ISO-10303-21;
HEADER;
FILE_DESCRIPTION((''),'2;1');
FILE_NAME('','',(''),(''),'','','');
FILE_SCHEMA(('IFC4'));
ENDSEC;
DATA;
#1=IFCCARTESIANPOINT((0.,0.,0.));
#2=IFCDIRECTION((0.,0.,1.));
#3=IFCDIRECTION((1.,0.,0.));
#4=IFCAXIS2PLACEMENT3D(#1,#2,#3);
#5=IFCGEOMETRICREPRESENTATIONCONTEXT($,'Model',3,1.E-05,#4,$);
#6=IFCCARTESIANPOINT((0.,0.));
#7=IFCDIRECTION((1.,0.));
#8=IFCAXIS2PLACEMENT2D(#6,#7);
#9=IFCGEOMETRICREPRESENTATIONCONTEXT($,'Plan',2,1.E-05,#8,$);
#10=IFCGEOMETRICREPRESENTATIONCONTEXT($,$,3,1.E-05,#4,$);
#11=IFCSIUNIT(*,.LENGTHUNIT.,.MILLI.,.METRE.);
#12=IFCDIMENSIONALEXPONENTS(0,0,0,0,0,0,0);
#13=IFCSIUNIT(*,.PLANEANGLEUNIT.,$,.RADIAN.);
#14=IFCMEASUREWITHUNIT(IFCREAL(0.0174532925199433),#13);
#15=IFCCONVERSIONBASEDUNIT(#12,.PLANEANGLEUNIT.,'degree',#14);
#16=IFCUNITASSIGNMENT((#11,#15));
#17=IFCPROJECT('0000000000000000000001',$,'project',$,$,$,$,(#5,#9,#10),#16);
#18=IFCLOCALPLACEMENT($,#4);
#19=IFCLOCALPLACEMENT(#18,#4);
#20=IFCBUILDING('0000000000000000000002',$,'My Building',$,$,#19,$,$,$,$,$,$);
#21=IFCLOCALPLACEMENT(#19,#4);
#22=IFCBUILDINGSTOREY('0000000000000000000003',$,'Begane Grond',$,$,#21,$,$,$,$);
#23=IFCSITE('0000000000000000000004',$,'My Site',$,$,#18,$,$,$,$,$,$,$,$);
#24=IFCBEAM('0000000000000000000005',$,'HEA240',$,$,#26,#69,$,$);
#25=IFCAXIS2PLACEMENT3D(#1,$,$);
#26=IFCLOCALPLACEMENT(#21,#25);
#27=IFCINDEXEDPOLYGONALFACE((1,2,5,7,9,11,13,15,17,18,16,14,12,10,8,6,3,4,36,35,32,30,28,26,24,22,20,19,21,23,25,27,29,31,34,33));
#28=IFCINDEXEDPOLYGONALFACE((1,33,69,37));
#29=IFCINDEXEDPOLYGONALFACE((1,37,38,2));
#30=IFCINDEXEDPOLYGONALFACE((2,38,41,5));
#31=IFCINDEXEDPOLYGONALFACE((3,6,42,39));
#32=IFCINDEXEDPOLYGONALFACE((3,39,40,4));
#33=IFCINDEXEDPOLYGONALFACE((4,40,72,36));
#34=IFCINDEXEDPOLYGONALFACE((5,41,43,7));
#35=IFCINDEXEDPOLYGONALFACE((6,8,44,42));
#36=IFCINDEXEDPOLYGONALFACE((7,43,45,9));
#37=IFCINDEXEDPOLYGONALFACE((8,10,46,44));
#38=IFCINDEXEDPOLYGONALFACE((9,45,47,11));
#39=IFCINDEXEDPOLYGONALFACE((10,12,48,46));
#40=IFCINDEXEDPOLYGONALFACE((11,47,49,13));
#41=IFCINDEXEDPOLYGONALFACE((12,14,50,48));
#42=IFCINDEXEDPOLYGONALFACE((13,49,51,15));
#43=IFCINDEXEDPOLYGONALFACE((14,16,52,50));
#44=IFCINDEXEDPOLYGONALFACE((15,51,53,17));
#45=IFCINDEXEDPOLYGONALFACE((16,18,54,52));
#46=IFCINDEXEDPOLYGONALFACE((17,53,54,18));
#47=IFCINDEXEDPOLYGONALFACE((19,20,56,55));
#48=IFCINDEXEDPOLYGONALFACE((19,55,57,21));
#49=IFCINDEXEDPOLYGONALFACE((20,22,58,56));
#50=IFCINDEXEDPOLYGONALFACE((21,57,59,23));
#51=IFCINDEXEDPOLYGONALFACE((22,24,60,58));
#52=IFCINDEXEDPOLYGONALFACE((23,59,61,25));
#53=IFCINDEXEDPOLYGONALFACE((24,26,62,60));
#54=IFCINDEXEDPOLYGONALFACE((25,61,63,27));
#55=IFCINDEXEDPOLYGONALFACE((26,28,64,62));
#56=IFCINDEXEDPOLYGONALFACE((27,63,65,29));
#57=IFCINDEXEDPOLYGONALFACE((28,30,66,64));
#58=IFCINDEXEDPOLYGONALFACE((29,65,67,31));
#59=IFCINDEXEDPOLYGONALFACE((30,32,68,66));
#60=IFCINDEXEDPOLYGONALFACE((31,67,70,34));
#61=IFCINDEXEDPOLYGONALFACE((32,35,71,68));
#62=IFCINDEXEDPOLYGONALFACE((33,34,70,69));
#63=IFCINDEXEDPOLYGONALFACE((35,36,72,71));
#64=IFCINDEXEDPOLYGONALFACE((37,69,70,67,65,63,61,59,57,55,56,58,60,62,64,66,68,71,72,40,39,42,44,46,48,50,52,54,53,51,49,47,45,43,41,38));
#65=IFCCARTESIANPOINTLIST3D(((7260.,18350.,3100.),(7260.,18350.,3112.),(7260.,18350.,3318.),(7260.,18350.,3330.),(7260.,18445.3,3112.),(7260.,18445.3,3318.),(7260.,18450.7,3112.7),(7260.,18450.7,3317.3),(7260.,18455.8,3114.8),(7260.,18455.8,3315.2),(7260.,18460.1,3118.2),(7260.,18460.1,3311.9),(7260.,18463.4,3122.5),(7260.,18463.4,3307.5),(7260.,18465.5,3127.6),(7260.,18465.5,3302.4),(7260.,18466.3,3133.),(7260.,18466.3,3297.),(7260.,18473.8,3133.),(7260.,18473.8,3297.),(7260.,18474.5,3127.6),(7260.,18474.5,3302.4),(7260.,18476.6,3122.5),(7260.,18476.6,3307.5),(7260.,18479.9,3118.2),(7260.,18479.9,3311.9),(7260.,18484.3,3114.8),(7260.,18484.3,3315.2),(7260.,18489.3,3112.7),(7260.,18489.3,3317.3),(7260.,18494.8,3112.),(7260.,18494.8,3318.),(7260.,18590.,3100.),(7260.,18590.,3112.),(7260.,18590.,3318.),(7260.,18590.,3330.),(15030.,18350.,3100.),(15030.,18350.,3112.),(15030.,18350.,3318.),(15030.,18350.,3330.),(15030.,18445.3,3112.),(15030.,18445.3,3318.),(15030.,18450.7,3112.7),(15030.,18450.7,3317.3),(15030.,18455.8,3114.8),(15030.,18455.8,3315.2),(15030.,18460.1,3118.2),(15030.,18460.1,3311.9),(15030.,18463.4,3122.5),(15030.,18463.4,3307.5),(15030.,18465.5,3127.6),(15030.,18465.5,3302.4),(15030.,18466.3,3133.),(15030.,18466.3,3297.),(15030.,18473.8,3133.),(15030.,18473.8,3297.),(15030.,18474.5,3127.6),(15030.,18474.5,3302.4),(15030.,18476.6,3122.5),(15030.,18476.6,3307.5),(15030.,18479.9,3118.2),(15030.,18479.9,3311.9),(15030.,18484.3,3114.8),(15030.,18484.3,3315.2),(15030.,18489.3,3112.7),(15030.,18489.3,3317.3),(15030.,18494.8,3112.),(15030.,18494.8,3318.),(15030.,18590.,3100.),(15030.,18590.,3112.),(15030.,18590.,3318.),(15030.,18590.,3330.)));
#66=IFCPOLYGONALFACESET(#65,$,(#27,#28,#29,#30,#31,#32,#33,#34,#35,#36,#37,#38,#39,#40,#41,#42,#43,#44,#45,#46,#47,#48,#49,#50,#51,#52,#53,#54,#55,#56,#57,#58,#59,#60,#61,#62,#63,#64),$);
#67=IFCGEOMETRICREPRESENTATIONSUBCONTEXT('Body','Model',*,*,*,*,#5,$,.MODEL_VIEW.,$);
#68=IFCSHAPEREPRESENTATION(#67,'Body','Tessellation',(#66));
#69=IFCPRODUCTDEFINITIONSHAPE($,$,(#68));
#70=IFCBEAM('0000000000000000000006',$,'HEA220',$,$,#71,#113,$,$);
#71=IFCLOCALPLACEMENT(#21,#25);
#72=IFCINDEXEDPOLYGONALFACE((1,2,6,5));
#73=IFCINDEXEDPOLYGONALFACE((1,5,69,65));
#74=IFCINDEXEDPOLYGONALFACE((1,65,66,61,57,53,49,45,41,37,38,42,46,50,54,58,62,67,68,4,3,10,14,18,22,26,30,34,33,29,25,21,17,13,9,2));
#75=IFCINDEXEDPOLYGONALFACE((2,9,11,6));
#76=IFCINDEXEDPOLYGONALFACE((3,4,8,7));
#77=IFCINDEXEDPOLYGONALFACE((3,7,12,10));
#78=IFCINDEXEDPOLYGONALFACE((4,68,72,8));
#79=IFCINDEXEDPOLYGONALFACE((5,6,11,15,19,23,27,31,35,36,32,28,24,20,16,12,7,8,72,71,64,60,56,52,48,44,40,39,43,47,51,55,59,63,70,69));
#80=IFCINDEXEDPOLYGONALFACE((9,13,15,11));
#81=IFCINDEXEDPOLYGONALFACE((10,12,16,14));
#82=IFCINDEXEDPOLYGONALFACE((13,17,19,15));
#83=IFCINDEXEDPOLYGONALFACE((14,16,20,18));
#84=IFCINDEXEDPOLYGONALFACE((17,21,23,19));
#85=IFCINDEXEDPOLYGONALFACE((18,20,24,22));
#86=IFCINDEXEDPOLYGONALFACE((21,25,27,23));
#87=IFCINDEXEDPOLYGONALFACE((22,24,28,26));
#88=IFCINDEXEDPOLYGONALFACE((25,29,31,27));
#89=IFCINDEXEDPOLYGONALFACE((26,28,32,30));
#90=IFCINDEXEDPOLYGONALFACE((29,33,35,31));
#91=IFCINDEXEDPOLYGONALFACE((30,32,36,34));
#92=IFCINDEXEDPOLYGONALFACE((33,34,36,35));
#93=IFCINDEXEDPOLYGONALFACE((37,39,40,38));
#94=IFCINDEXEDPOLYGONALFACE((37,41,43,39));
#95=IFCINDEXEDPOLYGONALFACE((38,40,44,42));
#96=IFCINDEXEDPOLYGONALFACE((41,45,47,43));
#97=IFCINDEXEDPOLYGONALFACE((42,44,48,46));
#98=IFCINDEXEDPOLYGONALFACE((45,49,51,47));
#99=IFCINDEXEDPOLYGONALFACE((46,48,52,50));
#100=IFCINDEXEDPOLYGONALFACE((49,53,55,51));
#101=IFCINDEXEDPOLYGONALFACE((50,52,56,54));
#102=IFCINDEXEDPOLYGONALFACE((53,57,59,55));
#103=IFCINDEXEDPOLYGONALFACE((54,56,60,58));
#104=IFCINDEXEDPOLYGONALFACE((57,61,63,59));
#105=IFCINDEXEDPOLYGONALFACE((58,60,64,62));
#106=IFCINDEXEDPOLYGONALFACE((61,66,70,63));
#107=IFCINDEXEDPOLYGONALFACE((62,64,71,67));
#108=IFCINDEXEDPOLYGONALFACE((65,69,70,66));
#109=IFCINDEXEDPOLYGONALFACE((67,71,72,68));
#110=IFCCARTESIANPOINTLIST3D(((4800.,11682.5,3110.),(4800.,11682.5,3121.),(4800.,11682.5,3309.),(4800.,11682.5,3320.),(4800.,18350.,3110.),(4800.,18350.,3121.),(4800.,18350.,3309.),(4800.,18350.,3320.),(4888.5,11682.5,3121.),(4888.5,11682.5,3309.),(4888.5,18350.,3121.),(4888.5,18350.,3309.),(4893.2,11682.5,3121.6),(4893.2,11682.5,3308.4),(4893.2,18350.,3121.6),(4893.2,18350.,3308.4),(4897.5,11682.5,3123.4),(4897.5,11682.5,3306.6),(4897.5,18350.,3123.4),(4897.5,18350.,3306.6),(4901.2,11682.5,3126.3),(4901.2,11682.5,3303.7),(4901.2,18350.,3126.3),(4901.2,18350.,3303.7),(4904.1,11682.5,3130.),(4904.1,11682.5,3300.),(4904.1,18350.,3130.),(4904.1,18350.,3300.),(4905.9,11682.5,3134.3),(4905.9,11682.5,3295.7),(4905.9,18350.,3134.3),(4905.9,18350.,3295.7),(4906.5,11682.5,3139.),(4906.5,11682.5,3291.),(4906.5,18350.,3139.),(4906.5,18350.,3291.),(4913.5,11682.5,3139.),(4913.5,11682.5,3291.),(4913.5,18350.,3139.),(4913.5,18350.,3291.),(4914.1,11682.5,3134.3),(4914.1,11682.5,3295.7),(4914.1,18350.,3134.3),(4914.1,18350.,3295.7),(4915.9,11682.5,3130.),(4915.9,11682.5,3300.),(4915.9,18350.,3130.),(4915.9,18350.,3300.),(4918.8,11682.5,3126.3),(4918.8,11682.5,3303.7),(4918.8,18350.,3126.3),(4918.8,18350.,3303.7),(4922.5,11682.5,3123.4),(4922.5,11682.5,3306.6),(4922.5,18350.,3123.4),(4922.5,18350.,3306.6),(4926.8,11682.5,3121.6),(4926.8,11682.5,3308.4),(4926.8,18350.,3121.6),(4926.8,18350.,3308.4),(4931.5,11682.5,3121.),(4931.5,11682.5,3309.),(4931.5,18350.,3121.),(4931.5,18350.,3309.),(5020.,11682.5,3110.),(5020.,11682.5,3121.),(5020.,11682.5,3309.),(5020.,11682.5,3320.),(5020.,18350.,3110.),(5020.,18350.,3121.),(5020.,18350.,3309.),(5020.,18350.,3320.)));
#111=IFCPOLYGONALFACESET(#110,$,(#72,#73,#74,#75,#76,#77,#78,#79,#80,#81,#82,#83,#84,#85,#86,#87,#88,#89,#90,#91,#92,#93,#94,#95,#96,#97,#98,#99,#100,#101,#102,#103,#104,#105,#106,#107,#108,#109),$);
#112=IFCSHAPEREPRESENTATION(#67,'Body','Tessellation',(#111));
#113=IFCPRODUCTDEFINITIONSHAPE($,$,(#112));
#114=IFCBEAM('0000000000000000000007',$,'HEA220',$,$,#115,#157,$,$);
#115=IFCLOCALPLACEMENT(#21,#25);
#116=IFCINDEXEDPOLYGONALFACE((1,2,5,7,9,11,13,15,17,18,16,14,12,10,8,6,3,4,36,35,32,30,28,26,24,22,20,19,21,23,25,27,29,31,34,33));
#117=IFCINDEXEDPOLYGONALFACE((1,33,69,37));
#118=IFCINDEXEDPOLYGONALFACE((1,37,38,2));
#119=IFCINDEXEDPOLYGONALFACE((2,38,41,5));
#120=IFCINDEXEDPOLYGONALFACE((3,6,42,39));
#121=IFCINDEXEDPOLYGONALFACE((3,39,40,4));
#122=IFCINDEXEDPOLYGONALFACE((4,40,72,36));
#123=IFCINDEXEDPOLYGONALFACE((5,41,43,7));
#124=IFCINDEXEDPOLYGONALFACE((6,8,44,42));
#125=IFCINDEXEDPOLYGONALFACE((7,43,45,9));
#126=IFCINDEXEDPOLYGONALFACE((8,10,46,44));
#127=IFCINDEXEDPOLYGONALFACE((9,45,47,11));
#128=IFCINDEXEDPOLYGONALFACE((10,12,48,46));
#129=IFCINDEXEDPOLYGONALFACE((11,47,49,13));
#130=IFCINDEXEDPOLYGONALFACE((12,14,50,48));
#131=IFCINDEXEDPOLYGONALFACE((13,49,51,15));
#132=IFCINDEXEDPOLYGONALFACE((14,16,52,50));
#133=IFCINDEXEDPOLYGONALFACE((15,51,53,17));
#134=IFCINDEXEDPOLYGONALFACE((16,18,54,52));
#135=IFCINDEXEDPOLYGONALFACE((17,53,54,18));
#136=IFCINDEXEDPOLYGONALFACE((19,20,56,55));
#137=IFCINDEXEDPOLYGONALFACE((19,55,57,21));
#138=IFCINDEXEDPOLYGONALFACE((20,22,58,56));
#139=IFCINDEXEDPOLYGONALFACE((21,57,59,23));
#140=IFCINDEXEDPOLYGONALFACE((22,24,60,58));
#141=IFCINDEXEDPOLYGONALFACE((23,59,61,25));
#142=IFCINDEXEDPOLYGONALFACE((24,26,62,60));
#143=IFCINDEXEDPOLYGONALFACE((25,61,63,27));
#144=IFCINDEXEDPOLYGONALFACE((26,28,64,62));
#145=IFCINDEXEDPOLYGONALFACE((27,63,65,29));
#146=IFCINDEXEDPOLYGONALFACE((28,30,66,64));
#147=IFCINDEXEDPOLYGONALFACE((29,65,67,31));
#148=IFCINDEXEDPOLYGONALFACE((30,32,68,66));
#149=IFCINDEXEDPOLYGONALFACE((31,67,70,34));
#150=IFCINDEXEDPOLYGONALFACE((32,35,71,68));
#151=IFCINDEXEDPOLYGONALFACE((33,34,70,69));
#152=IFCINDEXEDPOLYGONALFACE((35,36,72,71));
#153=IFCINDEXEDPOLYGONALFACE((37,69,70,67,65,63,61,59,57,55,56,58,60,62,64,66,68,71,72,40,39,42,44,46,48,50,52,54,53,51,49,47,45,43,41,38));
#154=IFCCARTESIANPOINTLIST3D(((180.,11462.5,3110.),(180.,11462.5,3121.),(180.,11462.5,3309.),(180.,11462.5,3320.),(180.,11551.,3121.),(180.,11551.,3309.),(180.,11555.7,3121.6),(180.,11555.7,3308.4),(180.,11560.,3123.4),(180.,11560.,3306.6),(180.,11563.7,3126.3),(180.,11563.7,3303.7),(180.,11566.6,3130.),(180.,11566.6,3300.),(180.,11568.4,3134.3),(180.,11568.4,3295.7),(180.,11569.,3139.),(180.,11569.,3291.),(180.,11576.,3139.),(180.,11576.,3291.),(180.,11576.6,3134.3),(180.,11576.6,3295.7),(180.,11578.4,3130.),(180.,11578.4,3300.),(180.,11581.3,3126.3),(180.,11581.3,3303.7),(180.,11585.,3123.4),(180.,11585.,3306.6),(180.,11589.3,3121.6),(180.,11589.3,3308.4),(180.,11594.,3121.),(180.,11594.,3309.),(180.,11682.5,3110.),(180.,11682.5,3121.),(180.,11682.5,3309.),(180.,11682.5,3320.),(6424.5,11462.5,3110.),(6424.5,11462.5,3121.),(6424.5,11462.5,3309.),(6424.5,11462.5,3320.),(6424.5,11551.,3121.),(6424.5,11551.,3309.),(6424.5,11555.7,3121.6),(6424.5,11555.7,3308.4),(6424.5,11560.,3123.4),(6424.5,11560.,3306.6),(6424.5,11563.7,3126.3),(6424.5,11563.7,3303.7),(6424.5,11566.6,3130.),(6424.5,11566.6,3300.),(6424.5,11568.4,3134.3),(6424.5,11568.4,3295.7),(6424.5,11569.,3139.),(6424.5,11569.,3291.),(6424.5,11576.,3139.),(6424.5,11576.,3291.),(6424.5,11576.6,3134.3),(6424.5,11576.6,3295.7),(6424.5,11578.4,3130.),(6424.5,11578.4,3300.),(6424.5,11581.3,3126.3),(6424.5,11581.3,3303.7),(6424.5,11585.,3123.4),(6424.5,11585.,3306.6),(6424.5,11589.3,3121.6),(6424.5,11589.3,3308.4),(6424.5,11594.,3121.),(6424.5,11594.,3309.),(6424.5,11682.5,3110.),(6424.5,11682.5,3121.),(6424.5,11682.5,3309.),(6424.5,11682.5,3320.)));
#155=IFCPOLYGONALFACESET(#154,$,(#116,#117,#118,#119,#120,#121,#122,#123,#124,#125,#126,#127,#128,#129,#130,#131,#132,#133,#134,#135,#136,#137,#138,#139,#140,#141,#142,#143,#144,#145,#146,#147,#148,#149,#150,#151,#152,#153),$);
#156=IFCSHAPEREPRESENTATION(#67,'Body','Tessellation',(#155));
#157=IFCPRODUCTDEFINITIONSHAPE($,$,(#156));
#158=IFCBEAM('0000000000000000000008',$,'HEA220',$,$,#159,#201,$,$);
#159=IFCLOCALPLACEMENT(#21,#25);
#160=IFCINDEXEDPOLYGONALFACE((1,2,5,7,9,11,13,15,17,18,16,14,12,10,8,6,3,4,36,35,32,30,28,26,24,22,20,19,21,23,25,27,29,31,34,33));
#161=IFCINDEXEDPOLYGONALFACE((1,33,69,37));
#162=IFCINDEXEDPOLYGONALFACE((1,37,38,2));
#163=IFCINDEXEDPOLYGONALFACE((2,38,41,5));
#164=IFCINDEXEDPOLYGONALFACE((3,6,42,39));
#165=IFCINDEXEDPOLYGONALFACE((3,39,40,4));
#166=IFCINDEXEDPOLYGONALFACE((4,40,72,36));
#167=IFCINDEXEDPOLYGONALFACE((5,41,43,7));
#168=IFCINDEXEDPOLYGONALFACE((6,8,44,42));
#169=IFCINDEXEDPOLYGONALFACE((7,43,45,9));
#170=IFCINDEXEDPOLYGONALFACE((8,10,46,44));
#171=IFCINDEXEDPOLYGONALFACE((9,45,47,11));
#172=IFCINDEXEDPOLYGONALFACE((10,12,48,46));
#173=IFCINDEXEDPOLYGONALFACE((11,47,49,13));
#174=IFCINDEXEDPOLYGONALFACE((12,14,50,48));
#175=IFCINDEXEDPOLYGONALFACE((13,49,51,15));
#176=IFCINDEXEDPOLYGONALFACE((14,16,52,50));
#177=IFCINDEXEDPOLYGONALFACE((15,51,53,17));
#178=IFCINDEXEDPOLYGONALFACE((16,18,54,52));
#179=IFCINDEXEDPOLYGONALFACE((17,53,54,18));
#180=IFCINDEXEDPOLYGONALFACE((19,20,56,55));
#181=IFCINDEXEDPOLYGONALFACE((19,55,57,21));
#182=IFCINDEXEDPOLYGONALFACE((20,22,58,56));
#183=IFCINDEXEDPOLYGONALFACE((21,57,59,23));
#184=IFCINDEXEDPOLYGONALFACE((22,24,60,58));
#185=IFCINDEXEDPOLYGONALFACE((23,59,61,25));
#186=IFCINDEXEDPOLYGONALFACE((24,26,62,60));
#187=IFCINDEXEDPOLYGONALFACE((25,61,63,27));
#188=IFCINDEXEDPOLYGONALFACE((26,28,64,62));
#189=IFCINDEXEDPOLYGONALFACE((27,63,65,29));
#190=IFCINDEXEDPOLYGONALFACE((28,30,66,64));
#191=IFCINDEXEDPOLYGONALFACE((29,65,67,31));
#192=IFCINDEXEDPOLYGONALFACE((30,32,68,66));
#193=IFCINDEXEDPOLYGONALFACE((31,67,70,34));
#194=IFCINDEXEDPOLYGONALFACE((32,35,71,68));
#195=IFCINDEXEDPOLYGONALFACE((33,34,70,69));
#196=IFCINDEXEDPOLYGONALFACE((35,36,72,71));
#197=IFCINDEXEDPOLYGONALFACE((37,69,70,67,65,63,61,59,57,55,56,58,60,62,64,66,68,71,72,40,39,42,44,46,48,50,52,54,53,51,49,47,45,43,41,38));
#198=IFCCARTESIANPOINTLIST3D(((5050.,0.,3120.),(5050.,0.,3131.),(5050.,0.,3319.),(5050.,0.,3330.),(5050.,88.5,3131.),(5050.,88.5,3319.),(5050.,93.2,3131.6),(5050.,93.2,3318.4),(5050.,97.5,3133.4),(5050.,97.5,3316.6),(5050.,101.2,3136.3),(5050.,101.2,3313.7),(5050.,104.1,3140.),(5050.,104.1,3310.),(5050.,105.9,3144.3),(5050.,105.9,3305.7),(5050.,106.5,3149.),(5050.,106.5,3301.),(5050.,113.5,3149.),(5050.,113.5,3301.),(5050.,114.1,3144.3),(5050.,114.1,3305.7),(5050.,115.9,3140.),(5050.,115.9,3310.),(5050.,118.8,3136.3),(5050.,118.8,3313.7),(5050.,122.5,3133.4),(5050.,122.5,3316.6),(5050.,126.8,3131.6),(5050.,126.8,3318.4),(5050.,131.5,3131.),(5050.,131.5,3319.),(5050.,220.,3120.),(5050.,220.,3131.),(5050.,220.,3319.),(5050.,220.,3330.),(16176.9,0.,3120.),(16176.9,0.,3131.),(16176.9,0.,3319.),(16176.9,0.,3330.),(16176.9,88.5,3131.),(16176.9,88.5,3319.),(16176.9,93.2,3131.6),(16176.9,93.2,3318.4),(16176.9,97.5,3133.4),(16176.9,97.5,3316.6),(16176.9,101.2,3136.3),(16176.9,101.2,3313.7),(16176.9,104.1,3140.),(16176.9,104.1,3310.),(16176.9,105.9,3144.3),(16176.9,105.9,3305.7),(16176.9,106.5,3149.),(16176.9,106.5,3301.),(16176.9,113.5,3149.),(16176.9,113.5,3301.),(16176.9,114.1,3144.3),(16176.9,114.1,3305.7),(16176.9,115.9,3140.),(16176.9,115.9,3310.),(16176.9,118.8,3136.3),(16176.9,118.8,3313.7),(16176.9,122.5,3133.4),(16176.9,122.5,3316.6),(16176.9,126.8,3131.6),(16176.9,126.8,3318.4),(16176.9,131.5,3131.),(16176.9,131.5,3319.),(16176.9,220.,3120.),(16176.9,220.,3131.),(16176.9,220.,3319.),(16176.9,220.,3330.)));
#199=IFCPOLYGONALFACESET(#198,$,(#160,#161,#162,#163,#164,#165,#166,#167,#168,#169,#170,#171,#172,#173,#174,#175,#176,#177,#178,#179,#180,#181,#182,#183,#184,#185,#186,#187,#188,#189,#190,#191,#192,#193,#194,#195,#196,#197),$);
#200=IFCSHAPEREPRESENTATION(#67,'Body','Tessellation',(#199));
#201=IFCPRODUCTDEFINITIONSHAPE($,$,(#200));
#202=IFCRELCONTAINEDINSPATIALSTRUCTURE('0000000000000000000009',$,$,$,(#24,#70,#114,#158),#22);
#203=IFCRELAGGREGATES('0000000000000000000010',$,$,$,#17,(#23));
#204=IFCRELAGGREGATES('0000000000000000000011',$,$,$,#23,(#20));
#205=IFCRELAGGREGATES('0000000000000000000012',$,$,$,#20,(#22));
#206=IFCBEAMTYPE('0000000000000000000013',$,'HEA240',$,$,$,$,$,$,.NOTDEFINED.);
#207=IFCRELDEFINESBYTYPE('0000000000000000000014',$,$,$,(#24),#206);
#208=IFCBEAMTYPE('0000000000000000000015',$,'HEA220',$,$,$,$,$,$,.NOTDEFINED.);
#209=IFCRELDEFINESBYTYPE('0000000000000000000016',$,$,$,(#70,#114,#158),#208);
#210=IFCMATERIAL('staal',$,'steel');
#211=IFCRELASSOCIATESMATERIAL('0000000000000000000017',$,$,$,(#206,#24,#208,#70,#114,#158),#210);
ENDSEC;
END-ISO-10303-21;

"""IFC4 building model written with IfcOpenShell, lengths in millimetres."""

from ifc_helpers import new_model, entity, si_unit, converted_unit, frame, origin_with_axes, origin_2d_with_axis, place, context, subcontext, project, spatial, i_section, extrude, material, material_profile, profile_set, profile_usage, type_object, element, save


model = new_model("IFC4")

# Units and contexts
model_context = context("Model", 3, precision=1e-05, world=origin_with_axes())
plan_context = context("Plan", 2, precision=1e-05, world=origin_2d_with_axis())
context_of_model = context(None, 3, precision=1e-05, world=origin_with_axes())
body_context = subcontext(model_context, "Body", "Model", "MODEL_VIEW")
ifc_project = project(units=[si_unit("LENGTHUNIT", "METRE", prefix="MILLI"), converted_unit("PLANEANGLEUNIT", "degree", entity("IfcReal", 0.0174532925199433), si_unit("PLANEANGLEUNIT", "RADIAN"), dimensions=[0, 0, 0, 0, 0, 0, 0])], contexts=[model_context, plan_context, context_of_model])

# Site, building, storey
site_placement = place(None, origin_with_axes())
site = spatial("IfcSite", under=ifc_project, at=site_placement, Name="My Site")
building_placement = place(site_placement, origin_with_axes())
building = spatial("IfcBuilding", under=site, at=building_placement, Name="My Building")
storey_placement = place(building_placement, origin_with_axes())
storey = spatial("IfcBuildingStorey", under=building, at=storey_placement, Name="Begane Grond")

# Shared definitions
ifc_material = material(Name="staal", Category="steel")

# Beams
ifc_material_profile_1 = material_profile(ifc_material, i_section(OverallWidth=240.0, OverallDepth=230.0, WebThickness=7.5, FlangeThickness=12.0, FilletRadius=21.0))
ifc_profile_set_1 = profile_set([ifc_material_profile_1], Name="HEA240")
beam_type_1 = type_object("IfcBeamType", Name="HEA240", PredefinedType="NOTDEFINED", material=ifc_profile_set_1)
ifc_profile_usage_1 = profile_usage(ifc_profile_set_1, cardinal=5)
beam_1_placement = place(storey_placement, frame((7260.0, 18470.0, 3215.0), z_axis=(1.0, 0.0, 0.0), x_axis=(0.0, 1.0, 0.0)))
element("IfcBeam", 1, at=beam_1_placement, inside=storey, type_object=beam_type_1, material=ifc_profile_usage_1, Name="HEA240", context=body_context, shape_type="SweptSolid", body=[
    extrude(i_section(OverallWidth=240.0, OverallDepth=230.0, WebThickness=7.5, FlangeThickness=12.0, FilletRadius=21.0), origin_with_axes(), (0.0, 0.0, 1.0), 7770.0),
])
ifc_material_profile_2 = material_profile(ifc_material, i_section(OverallWidth=220.0, OverallDepth=210.0, WebThickness=7.0, FlangeThickness=11.0, FilletRadius=18.0))
ifc_profile_set_2 = profile_set([ifc_material_profile_2], Name="HEA220")
ifc_profile_usage_2 = profile_usage(ifc_profile_set_2)
beam_type_2 = type_object("IfcBeamType", Name="HEA220", PredefinedType="NOTDEFINED", material=ifc_profile_set_2)
beam_2_placement = place(storey_placement, frame((4910.0, 18350.0, 3215.0), z_axis=(0.0, -1.0, 0.0), x_axis=(1.0, 0.0, 0.0)))
element("IfcBeam", 2, at=beam_2_placement, inside=storey, type_object=beam_type_2, material=ifc_profile_usage_2, Name="HEA220", context=body_context, shape_type="SweptSolid", body=[
    extrude(i_section(OverallWidth=220.0, OverallDepth=210.0, WebThickness=7.0, FlangeThickness=11.0, FilletRadius=18.0), origin_with_axes(), (0.0, 0.0, 1.0), 6667.5),
])
ifc_profile_usage_3 = profile_usage(ifc_profile_set_2)
beam_3_placement = place(storey_placement, frame((180.0, 11572.5, 3215.0), z_axis=(1.0, 0.0, 0.0), x_axis=(0.0, 1.0, 0.0)))
element("IfcBeam", 3, at=beam_3_placement, inside=storey, type_object=beam_type_2, material=ifc_profile_usage_3, Name="HEA220", context=body_context, shape_type="SweptSolid", body=[
    extrude(i_section(OverallWidth=220.0, OverallDepth=210.0, WebThickness=7.0, FlangeThickness=11.0, FilletRadius=18.0), origin_with_axes(), (0.0, 0.0, 1.0), 6244.5),
])
ifc_profile_usage_4 = profile_usage(ifc_profile_set_2)
beam_4_placement = place(storey_placement, frame((5050.0, 110.0, 3225.0), z_axis=(1.0, 0.0, 0.0), x_axis=(0.0, 1.0, 0.0)))
element("IfcBeam", 4, at=beam_4_placement, inside=storey, type_object=beam_type_2, material=ifc_profile_usage_4, Name="HEA220", context=body_context, shape_type="SweptSolid", body=[
    extrude(i_section(OverallWidth=220.0, OverallDepth=210.0, WebThickness=7.0, FlangeThickness=11.0, FilletRadius=18.0), origin_with_axes(), (0.0, 0.0, 1.0), 11126.9),
])

save(model, "model.ifc")
